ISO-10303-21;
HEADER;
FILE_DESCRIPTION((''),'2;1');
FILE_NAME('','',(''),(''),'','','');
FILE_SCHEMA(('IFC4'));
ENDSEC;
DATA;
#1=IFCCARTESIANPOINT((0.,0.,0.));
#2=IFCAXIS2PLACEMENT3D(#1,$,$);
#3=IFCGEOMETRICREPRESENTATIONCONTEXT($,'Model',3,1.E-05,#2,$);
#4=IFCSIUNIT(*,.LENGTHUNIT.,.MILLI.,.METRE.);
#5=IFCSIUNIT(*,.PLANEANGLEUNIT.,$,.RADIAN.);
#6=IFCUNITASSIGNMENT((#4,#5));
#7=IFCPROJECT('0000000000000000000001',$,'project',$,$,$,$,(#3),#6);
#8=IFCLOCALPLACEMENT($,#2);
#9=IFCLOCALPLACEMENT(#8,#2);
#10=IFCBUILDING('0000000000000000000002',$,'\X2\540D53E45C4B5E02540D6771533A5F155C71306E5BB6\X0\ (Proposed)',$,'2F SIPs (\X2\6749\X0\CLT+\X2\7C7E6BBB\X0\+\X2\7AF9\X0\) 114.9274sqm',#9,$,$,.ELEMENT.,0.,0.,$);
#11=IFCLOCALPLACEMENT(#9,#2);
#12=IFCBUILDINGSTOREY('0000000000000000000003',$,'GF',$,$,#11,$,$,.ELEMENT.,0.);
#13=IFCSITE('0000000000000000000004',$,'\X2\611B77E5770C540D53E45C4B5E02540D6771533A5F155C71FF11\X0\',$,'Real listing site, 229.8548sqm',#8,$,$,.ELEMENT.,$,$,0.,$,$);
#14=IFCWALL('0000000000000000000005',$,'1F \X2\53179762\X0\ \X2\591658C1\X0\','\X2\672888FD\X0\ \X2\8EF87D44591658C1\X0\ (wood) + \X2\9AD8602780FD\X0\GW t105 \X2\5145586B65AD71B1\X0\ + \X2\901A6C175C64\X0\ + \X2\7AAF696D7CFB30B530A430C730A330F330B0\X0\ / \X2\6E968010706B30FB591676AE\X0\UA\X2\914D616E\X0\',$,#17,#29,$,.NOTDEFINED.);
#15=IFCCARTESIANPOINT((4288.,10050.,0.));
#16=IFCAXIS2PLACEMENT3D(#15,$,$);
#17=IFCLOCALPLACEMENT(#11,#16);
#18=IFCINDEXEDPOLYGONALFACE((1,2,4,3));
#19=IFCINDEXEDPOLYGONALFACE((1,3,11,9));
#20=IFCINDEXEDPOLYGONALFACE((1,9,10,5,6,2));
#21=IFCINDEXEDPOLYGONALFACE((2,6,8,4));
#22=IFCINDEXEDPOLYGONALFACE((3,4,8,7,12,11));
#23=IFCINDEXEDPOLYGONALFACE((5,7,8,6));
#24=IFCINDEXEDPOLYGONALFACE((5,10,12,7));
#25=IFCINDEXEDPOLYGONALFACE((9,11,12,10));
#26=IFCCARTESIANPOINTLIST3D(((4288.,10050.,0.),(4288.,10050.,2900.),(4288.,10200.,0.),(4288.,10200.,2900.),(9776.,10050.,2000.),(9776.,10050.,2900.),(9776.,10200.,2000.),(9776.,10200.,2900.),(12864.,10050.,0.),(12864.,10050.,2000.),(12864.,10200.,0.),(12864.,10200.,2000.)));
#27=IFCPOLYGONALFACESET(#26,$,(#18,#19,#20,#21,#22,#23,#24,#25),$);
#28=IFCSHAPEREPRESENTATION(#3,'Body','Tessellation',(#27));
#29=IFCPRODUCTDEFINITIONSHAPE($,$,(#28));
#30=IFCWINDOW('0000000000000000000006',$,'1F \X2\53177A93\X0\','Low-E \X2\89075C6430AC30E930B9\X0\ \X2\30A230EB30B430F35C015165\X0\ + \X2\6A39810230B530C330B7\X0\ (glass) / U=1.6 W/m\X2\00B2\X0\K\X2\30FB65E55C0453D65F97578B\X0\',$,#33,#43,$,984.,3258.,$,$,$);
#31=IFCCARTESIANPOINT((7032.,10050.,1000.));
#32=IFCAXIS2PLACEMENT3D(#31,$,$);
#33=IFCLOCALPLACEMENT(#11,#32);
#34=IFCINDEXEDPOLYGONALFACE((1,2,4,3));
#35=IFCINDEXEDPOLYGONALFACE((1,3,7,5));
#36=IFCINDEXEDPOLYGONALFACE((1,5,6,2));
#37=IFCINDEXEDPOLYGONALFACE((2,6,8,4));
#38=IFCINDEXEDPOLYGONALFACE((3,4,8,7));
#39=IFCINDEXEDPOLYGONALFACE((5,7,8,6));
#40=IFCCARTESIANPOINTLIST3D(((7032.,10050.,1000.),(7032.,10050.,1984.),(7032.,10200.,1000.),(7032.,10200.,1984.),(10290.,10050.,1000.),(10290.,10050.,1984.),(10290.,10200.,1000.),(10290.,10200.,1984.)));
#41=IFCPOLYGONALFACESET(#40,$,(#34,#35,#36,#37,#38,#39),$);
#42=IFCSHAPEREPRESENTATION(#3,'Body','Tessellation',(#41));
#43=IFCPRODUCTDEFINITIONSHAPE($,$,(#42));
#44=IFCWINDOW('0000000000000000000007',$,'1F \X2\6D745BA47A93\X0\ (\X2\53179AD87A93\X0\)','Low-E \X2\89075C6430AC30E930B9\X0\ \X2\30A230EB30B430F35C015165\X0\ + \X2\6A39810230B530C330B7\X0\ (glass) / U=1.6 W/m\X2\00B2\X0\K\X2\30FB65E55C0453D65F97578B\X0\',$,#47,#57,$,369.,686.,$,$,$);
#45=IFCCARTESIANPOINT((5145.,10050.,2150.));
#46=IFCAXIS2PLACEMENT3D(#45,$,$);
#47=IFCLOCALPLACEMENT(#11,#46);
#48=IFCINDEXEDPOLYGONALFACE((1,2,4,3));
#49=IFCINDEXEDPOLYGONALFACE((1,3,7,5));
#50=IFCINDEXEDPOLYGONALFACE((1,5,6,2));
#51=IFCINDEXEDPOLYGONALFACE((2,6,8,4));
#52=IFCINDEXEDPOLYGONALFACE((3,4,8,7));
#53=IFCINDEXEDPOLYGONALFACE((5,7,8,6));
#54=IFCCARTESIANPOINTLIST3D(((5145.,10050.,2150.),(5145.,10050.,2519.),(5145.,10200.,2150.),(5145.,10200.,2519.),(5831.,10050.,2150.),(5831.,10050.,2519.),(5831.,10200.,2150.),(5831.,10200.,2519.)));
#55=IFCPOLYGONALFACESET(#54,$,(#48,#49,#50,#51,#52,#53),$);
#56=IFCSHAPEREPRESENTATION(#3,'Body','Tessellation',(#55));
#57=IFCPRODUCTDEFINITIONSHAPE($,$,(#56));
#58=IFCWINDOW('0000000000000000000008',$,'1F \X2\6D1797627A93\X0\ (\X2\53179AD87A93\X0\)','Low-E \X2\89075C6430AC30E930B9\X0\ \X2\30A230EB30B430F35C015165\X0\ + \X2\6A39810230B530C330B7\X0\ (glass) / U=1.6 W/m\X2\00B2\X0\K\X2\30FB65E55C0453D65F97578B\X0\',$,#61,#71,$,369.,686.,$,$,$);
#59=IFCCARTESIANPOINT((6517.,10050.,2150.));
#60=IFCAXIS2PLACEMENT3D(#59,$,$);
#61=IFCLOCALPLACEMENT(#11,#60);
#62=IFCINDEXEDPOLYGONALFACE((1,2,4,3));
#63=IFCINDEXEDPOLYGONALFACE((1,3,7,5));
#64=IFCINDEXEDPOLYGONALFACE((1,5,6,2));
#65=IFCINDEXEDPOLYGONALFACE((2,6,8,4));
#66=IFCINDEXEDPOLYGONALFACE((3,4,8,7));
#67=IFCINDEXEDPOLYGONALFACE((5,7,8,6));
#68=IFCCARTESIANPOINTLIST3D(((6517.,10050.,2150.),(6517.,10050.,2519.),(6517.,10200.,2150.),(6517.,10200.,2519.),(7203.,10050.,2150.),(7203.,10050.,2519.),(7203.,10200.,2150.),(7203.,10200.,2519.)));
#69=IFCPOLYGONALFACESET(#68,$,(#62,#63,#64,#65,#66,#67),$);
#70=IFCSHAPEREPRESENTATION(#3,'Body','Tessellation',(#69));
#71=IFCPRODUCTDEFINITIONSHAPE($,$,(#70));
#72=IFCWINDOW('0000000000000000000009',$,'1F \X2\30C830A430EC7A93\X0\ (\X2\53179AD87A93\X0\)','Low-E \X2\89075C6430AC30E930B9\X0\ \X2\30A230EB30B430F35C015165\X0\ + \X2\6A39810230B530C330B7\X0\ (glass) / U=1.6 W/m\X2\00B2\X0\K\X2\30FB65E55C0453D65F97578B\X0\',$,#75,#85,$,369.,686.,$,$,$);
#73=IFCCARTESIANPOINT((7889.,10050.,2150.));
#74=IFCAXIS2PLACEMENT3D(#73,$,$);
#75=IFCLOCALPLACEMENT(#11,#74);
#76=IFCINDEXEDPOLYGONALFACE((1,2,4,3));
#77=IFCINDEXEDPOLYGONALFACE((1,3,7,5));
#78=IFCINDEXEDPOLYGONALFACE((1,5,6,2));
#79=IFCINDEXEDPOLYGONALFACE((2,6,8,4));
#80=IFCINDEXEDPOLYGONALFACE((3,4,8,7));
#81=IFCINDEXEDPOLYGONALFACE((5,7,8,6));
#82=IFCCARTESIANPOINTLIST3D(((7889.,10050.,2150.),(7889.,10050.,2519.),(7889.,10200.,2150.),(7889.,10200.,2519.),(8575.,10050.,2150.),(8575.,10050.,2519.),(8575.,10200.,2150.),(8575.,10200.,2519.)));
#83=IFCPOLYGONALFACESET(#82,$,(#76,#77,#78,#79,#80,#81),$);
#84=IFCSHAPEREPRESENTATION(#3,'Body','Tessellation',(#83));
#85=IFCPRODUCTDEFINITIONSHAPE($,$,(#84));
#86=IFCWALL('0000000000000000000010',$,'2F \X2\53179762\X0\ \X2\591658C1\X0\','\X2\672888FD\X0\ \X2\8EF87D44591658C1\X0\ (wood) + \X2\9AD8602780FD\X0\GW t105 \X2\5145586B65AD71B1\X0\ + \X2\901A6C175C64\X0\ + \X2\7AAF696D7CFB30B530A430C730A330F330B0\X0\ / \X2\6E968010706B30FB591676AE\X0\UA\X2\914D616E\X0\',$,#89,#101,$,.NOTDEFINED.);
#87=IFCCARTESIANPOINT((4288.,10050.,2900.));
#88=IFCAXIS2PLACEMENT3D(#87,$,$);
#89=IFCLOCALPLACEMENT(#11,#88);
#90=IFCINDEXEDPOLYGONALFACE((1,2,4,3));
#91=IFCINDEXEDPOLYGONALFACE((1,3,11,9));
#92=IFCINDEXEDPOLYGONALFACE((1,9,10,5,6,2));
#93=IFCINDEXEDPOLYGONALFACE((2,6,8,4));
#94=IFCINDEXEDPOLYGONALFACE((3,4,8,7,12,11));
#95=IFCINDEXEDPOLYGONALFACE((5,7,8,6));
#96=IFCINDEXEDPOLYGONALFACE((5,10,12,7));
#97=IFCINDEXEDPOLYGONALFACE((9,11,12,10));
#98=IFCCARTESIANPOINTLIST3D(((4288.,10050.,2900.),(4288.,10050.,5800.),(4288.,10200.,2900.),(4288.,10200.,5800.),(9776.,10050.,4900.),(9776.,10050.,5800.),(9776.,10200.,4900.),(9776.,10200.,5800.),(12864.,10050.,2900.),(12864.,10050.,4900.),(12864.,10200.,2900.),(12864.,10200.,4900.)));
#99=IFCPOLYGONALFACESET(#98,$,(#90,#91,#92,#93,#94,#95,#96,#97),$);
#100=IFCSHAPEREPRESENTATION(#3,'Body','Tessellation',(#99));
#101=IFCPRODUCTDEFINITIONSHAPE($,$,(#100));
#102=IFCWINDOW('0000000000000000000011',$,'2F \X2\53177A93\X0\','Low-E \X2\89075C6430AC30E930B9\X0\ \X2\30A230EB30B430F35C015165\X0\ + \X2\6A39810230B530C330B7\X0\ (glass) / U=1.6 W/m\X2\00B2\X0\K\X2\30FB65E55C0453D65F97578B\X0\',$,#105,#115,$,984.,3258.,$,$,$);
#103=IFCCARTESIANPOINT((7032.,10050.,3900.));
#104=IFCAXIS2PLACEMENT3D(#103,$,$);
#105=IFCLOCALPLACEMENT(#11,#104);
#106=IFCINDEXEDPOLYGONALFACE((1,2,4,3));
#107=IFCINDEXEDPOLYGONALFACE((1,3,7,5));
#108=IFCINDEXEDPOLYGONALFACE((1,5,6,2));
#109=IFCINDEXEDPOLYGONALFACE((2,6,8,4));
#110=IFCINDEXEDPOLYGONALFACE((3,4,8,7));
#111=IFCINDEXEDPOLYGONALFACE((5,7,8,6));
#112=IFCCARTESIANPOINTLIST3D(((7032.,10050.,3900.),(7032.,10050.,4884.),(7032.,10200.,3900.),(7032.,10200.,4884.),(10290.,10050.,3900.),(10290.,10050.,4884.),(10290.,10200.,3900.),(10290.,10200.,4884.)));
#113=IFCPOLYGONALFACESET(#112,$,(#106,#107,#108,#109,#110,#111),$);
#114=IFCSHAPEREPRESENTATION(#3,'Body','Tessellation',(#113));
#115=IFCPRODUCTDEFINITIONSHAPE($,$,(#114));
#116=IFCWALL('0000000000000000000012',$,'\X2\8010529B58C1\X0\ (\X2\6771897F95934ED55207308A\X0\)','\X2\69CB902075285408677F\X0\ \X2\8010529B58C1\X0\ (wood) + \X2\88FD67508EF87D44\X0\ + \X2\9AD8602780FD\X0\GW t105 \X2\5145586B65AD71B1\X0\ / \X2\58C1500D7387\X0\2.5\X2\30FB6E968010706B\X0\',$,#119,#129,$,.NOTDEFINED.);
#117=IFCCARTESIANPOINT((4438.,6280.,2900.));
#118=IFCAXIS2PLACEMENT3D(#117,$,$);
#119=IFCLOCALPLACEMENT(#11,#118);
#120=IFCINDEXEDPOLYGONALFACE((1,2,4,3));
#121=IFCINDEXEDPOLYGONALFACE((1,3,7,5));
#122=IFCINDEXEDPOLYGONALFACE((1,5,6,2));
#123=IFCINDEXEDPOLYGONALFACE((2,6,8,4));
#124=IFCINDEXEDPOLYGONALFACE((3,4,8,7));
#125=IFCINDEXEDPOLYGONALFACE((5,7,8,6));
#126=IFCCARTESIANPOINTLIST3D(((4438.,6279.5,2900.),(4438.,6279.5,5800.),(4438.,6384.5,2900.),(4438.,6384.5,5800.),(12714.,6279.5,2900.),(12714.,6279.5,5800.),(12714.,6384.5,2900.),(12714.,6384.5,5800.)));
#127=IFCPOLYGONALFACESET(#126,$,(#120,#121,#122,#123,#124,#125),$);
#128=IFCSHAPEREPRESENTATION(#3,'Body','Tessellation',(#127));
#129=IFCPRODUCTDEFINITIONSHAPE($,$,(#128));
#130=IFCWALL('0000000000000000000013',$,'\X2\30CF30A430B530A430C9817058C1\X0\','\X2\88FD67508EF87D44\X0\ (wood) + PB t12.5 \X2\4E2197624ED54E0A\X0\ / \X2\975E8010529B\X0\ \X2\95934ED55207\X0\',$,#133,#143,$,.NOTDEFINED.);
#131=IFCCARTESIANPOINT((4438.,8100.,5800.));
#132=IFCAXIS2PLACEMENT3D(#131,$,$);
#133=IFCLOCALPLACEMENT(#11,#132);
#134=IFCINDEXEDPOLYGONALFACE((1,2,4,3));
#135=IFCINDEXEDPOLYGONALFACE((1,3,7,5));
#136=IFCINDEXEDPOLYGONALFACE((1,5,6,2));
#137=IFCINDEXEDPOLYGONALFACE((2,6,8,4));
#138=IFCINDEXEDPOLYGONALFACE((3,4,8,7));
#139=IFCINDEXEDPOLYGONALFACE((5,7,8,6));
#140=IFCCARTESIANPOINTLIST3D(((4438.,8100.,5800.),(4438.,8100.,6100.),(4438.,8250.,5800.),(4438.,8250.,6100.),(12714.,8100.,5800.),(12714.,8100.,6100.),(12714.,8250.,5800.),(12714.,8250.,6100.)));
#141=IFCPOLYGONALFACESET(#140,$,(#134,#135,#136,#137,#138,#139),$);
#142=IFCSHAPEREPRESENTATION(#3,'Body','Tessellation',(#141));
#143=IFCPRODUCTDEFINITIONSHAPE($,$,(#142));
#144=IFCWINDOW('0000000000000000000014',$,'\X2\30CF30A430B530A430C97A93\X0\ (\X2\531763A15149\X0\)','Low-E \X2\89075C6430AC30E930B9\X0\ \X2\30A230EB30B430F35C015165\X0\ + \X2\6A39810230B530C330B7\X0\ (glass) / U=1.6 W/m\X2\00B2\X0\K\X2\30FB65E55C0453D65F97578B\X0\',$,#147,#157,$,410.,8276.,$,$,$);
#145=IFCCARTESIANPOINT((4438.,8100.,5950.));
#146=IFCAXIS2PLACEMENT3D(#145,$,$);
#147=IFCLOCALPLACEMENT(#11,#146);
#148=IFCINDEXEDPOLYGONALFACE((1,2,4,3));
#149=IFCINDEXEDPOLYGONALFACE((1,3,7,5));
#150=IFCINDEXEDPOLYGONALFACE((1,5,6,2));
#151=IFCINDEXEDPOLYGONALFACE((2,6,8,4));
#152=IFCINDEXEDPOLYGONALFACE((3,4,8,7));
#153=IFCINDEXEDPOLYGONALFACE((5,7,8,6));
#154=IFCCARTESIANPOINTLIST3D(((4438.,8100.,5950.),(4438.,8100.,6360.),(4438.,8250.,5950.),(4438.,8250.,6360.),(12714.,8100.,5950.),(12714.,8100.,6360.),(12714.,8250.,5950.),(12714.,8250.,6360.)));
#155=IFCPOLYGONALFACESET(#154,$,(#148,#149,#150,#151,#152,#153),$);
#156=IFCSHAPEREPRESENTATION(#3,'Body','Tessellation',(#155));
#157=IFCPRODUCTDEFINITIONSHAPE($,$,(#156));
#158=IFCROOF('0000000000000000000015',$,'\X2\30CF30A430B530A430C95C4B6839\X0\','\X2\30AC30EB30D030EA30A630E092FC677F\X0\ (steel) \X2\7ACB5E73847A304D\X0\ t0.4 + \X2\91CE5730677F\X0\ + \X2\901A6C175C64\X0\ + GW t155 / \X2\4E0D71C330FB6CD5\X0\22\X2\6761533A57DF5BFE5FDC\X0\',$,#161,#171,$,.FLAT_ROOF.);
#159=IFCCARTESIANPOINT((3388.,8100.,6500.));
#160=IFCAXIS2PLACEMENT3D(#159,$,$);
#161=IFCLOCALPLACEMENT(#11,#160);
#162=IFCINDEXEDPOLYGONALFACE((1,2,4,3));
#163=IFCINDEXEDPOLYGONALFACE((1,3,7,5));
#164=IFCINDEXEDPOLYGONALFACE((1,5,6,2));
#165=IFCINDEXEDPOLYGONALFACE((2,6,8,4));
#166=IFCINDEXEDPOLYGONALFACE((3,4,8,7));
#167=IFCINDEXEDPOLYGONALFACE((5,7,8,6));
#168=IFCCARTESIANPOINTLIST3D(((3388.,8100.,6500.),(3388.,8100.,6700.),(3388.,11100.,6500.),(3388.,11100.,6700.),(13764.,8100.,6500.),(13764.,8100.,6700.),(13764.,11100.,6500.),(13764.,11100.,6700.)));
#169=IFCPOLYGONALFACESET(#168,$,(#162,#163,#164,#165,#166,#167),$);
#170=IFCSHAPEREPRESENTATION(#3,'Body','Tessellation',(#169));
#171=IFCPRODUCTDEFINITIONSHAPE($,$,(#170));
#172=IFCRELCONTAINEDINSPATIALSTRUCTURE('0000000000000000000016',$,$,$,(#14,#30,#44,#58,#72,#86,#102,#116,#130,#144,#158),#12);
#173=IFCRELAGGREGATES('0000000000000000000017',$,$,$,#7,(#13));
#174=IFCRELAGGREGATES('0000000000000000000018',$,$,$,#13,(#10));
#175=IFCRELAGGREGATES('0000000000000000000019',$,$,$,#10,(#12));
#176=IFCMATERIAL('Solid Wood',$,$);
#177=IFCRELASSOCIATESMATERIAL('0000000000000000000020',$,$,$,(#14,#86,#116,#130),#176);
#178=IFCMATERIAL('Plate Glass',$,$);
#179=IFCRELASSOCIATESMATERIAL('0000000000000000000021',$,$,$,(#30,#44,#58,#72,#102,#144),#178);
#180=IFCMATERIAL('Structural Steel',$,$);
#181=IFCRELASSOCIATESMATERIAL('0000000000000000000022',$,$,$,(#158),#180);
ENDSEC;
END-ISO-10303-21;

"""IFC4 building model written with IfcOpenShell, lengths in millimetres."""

from ifc_helpers import new_model, si_unit, frame, frame_2d, origin, place, context, project, spatial, rectangle, extrude, material, element, fill, save


model = new_model("IFC4")

# Units and contexts
model_context = context("Model", 3, precision=1e-05, world=origin())
ifc_project = project(units=[si_unit("LENGTHUNIT", "METRE", prefix="MILLI"), si_unit("PLANEANGLEUNIT", "RADIAN")], contexts=[model_context])

# Site, building, storey
site_placement = place(None, origin())
site = spatial("IfcSite", under=ifc_project, at=site_placement, Name="愛知県名古屋市名東区引山１", ObjectType="Real listing site, 229.8548sqm", CompositionType="ELEMENT", RefElevation=0.0)
building_placement = place(site_placement, origin())
building = spatial("IfcBuilding", under=site, at=building_placement, Name="名古屋市名東区引山の家 (Proposed)", ObjectType="2F SIPs (杉CLT+籾殻+竹) 114.9274sqm", CompositionType="ELEMENT", ElevationOfRefHeight=0.0, ElevationOfTerrain=0.0)
storey_placement = place(building_placement, origin())
storey = spatial("IfcBuildingStorey", under=building, at=storey_placement, Name="GF", CompositionType="ELEMENT", Elevation=0.0)

# Wall, openings, windows
ifc_material_1 = material(Name="Solid Wood")
wall_1_placement = place(storey_placement, frame((4288.0, 10050.0, 0.0)))
wall_1 = element("IfcWall", 1, at=wall_1_placement, inside=storey, material=ifc_material_1, Name="1F 北面 外壁", Description="木製 軸組外壁 (wood) + 高性能GW t105 充填断熱 + 通気層 + 窯業系サイディング / 準耐火・外皮UA配慮", PredefinedType="NOTDEFINED", context=model_context, shape_type="SweptSolid", body=[
    extrude(rectangle(XDim=8576.0, YDim=150.0, at=frame_2d((4288.0, 75.0))), frame((4288.0, 10050.0, 0.0)), (0.0, 0.0, 1.0), 2900.0),
])
opening_1_placement = place(storey_placement, frame((7032.0, 10050.0, 1000.0)))
opening_1 = element("IfcOpeningElement", 2, at=opening_1_placement, cuts=wall_1, PredefinedType="NOTDEFINED", context=model_context, shape_type="SweptSolid", body=[
    extrude(rectangle(XDim=3258.0, YDim=150.0, at=frame_2d((1629.0, 75.0))), frame((7032.0, 10050.0, 1000.0)), (0.0, 0.0, 1.0), 984.0),
])
opening_2_placement = place(storey_placement, frame((5145.0, 10050.0, 2150.0)))
opening_2 = element("IfcOpeningElement", 3, at=opening_2_placement, cuts=wall_1, PredefinedType="NOTDEFINED", context=model_context, shape_type="SweptSolid", body=[
    extrude(rectangle(XDim=686.0, YDim=150.0, at=frame_2d((343.0, 75.0))), frame((5145.0, 10050.0, 2150.0)), (0.0, 0.0, 1.0), 369.0),
])
opening_3_placement = place(storey_placement, frame((6517.0, 10050.0, 2150.0)))
opening_3 = element("IfcOpeningElement", 4, at=opening_3_placement, cuts=wall_1, PredefinedType="NOTDEFINED", context=model_context, shape_type="SweptSolid", body=[
    extrude(rectangle(XDim=686.0, YDim=150.0, at=frame_2d((343.0, 75.0))), frame((6517.0, 10050.0, 2150.0)), (0.0, 0.0, 1.0), 369.0),
])
opening_4_placement = place(storey_placement, frame((7889.0, 10050.0, 2150.0)))
opening_4 = element("IfcOpeningElement", 5, at=opening_4_placement, cuts=wall_1, PredefinedType="NOTDEFINED", context=model_context, shape_type="SweptSolid", body=[
    extrude(rectangle(XDim=686.0, YDim=150.0, at=frame_2d((343.0, 75.0))), frame((7889.0, 10050.0, 2150.0)), (0.0, 0.0, 1.0), 369.0),
])
ifc_material_2 = material(Name="Plate Glass")
window_1_placement = place(storey_placement, frame((7032.0, 10050.0, 1000.0)))
window_1 = element("IfcWindow", 6, at=window_1_placement, inside=storey, material=ifc_material_2, Name="1F 北窓", Description="Low-E 複層ガラス アルゴン封入 + 樹脂サッシ (glass) / U=1.6 W/m²K・日射取得型", OverallHeight=984.0, OverallWidth=3258.0, context=model_context, shape_type="SweptSolid", body=[
    extrude(rectangle(XDim=3258.0, YDim=150.0, at=frame_2d((1629.0, 75.0))), frame((7032.0, 10050.0, 1000.0)), (0.0, 0.0, 1.0), 984.0),
])
fill(opening_1, window_1)
window_2_placement = place(storey_placement, frame((5145.0, 10050.0, 2150.0)))
window_2 = element("IfcWindow", 7, at=window_2_placement, inside=storey, material=ifc_material_2, Name="1F 浴室窓 (北高窓)", Description="Low-E 複層ガラス アルゴン封入 + 樹脂サッシ (glass) / U=1.6 W/m²K・日射取得型", OverallHeight=369.0, OverallWidth=686.0, context=model_context, shape_type="SweptSolid", body=[
    extrude(rectangle(XDim=686.0, YDim=150.0, at=frame_2d((343.0, 75.0))), frame((5145.0, 10050.0, 2150.0)), (0.0, 0.0, 1.0), 369.0),
])
fill(opening_2, window_2)
window_3_placement = place(storey_placement, frame((6517.0, 10050.0, 2150.0)))
window_3 = element("IfcWindow", 8, at=window_3_placement, inside=storey, material=ifc_material_2, Name="1F 洗面窓 (北高窓)", Description="Low-E 複層ガラス アルゴン封入 + 樹脂サッシ (glass) / U=1.6 W/m²K・日射取得型", OverallHeight=369.0, OverallWidth=686.0, context=model_context, shape_type="SweptSolid", body=[
    extrude(rectangle(XDim=686.0, YDim=150.0, at=frame_2d((343.0, 75.0))), frame((6517.0, 10050.0, 2150.0)), (0.0, 0.0, 1.0), 369.0),
])
fill(opening_3, window_3)
window_4_placement = place(storey_placement, frame((7889.0, 10050.0, 2150.0)))
window_4 = element("IfcWindow", 9, at=window_4_placement, inside=storey, material=ifc_material_2, Name="1F トイレ窓 (北高窓)", Description="Low-E 複層ガラス アルゴン封入 + 樹脂サッシ (glass) / U=1.6 W/m²K・日射取得型", OverallHeight=369.0, OverallWidth=686.0, context=model_context, shape_type="SweptSolid", body=[
    extrude(rectangle(XDim=686.0, YDim=150.0, at=frame_2d((343.0, 75.0))), frame((7889.0, 10050.0, 2150.0)), (0.0, 0.0, 1.0), 369.0),
])
fill(opening_4, window_4)

# Wall, opening, window
wall_2_placement = place(storey_placement, frame((4288.0, 10050.0, 2900.0)))
wall_2 = element("IfcWall", 10, at=wall_2_placement, inside=storey, material=ifc_material_1, Name="2F 北面 外壁", Description="木製 軸組外壁 (wood) + 高性能GW t105 充填断熱 + 通気層 + 窯業系サイディング / 準耐火・外皮UA配慮", PredefinedType="NOTDEFINED", context=model_context, shape_type="SweptSolid", body=[
    extrude(rectangle(XDim=8576.0, YDim=150.0, at=frame_2d((4288.0, 75.0))), frame((4288.0, 10050.0, 2900.0)), (0.0, 0.0, 1.0), 2900.0),
])
opening_5_placement = place(storey_placement, frame((7032.0, 10050.0, 3900.0)))
opening_5 = element("IfcOpeningElement", 11, at=opening_5_placement, cuts=wall_2, PredefinedType="NOTDEFINED", context=model_context, shape_type="SweptSolid", body=[
    extrude(rectangle(XDim=3258.0, YDim=150.0, at=frame_2d((1629.0, 75.0))), frame((7032.0, 10050.0, 3900.0)), (0.0, 0.0, 1.0), 984.0),
])
window_5_placement = place(storey_placement, frame((7032.0, 10050.0, 3900.0)))
window_5 = element("IfcWindow", 12, at=window_5_placement, inside=storey, material=ifc_material_2, Name="2F 北窓", Description="Low-E 複層ガラス アルゴン封入 + 樹脂サッシ (glass) / U=1.6 W/m²K・日射取得型", OverallHeight=984.0, OverallWidth=3258.0, context=model_context, shape_type="SweptSolid", body=[
    extrude(rectangle(XDim=3258.0, YDim=150.0, at=frame_2d((1629.0, 75.0))), frame((7032.0, 10050.0, 3900.0)), (0.0, 0.0, 1.0), 984.0),
])
fill(opening_5, window_5)

# Wall
wall_3_placement = place(storey_placement, frame((4438.0, 6280.0, 2900.0)))
element("IfcWall", 13, at=wall_3_placement, inside=storey, material=ifc_material_1, Name="耐力壁 (東西間仕切り)", Description="構造用合板 耐力壁 (wood) + 製材軸組 + 高性能GW t105 充填断熱 / 壁倍率2.5・準耐火", PredefinedType="NOTDEFINED", context=model_context, shape_type="SweptSolid", body=[
    extrude(rectangle(XDim=8276.0, YDim=105.0, at=frame_2d((4138.0, 52.0))), frame((4438.0, 6280.0, 2900.0)), (0.0, 0.0, 1.0), 2900.0),
])

# Wall, opening, window
wall_4_placement = place(storey_placement, frame((4438.0, 8100.0, 5800.0)))
wall_4 = element("IfcWall", 14, at=wall_4_placement, inside=storey, material=ifc_material_1, Name="ハイサイド腰壁", Description="製材軸組 (wood) + PB t12.5 両面仕上 / 非耐力 間仕切", PredefinedType="NOTDEFINED", context=model_context, shape_type="SweptSolid", body=[
    extrude(rectangle(XDim=8276.0, YDim=150.0, at=frame_2d((4138.0, 75.0))), frame((4438.0, 8100.0, 5800.0)), (0.0, 0.0, 1.0), 700.0),
])
opening_6_placement = place(storey_placement, frame((4438.0, 8100.0, 5950.0)))
opening_6 = element("IfcOpeningElement", 15, at=opening_6_placement, cuts=wall_4, PredefinedType="NOTDEFINED", context=model_context, shape_type="SweptSolid", body=[
    extrude(rectangle(XDim=8276.0, YDim=150.0, at=frame_2d((4138.0, 75.0))), frame((4438.0, 8100.0, 5950.0)), (0.0, 0.0, 1.0), 410.0),
])
window_6_placement = place(storey_placement, frame((4438.0, 8100.0, 5950.0)))
window_6 = element("IfcWindow", 16, at=window_6_placement, inside=storey, material=ifc_material_2, Name="ハイサイド窓 (北採光)", Description="Low-E 複層ガラス アルゴン封入 + 樹脂サッシ (glass) / U=1.6 W/m²K・日射取得型", OverallHeight=410.0, OverallWidth=8276.0, context=model_context, shape_type="SweptSolid", body=[
    extrude(rectangle(XDim=8276.0, YDim=150.0, at=frame_2d((4138.0, 75.0))), frame((4438.0, 8100.0, 5950.0)), (0.0, 0.0, 1.0), 410.0),
])
fill(opening_6, window_6)

# Roof
ifc_material_3 = material(Name="Structural Steel")
roof_placement = place(storey_placement, frame((3388.0, 8100.0, 6500.0)))
element("IfcRoof", 17, at=roof_placement, inside=storey, material=ifc_material_3, Name="ハイサイド屋根", Description="ガルバリウム鋼板 (steel) 立平葺き t0.4 + 野地板 + 通気層 + GW t155 / 不燃・法22条区域対応", PredefinedType="FLAT_ROOF", context=model_context, shape_type="SweptSolid", body=[
    extrude(rectangle(XDim=10376.0, YDim=3000.0, at=frame_2d((5188.0, 1500.0))), frame((3388.0, 8100.0, 6500.0)), (0.0, 0.0, 1.0), 200.0),
])

save(model, "model.ifc")
